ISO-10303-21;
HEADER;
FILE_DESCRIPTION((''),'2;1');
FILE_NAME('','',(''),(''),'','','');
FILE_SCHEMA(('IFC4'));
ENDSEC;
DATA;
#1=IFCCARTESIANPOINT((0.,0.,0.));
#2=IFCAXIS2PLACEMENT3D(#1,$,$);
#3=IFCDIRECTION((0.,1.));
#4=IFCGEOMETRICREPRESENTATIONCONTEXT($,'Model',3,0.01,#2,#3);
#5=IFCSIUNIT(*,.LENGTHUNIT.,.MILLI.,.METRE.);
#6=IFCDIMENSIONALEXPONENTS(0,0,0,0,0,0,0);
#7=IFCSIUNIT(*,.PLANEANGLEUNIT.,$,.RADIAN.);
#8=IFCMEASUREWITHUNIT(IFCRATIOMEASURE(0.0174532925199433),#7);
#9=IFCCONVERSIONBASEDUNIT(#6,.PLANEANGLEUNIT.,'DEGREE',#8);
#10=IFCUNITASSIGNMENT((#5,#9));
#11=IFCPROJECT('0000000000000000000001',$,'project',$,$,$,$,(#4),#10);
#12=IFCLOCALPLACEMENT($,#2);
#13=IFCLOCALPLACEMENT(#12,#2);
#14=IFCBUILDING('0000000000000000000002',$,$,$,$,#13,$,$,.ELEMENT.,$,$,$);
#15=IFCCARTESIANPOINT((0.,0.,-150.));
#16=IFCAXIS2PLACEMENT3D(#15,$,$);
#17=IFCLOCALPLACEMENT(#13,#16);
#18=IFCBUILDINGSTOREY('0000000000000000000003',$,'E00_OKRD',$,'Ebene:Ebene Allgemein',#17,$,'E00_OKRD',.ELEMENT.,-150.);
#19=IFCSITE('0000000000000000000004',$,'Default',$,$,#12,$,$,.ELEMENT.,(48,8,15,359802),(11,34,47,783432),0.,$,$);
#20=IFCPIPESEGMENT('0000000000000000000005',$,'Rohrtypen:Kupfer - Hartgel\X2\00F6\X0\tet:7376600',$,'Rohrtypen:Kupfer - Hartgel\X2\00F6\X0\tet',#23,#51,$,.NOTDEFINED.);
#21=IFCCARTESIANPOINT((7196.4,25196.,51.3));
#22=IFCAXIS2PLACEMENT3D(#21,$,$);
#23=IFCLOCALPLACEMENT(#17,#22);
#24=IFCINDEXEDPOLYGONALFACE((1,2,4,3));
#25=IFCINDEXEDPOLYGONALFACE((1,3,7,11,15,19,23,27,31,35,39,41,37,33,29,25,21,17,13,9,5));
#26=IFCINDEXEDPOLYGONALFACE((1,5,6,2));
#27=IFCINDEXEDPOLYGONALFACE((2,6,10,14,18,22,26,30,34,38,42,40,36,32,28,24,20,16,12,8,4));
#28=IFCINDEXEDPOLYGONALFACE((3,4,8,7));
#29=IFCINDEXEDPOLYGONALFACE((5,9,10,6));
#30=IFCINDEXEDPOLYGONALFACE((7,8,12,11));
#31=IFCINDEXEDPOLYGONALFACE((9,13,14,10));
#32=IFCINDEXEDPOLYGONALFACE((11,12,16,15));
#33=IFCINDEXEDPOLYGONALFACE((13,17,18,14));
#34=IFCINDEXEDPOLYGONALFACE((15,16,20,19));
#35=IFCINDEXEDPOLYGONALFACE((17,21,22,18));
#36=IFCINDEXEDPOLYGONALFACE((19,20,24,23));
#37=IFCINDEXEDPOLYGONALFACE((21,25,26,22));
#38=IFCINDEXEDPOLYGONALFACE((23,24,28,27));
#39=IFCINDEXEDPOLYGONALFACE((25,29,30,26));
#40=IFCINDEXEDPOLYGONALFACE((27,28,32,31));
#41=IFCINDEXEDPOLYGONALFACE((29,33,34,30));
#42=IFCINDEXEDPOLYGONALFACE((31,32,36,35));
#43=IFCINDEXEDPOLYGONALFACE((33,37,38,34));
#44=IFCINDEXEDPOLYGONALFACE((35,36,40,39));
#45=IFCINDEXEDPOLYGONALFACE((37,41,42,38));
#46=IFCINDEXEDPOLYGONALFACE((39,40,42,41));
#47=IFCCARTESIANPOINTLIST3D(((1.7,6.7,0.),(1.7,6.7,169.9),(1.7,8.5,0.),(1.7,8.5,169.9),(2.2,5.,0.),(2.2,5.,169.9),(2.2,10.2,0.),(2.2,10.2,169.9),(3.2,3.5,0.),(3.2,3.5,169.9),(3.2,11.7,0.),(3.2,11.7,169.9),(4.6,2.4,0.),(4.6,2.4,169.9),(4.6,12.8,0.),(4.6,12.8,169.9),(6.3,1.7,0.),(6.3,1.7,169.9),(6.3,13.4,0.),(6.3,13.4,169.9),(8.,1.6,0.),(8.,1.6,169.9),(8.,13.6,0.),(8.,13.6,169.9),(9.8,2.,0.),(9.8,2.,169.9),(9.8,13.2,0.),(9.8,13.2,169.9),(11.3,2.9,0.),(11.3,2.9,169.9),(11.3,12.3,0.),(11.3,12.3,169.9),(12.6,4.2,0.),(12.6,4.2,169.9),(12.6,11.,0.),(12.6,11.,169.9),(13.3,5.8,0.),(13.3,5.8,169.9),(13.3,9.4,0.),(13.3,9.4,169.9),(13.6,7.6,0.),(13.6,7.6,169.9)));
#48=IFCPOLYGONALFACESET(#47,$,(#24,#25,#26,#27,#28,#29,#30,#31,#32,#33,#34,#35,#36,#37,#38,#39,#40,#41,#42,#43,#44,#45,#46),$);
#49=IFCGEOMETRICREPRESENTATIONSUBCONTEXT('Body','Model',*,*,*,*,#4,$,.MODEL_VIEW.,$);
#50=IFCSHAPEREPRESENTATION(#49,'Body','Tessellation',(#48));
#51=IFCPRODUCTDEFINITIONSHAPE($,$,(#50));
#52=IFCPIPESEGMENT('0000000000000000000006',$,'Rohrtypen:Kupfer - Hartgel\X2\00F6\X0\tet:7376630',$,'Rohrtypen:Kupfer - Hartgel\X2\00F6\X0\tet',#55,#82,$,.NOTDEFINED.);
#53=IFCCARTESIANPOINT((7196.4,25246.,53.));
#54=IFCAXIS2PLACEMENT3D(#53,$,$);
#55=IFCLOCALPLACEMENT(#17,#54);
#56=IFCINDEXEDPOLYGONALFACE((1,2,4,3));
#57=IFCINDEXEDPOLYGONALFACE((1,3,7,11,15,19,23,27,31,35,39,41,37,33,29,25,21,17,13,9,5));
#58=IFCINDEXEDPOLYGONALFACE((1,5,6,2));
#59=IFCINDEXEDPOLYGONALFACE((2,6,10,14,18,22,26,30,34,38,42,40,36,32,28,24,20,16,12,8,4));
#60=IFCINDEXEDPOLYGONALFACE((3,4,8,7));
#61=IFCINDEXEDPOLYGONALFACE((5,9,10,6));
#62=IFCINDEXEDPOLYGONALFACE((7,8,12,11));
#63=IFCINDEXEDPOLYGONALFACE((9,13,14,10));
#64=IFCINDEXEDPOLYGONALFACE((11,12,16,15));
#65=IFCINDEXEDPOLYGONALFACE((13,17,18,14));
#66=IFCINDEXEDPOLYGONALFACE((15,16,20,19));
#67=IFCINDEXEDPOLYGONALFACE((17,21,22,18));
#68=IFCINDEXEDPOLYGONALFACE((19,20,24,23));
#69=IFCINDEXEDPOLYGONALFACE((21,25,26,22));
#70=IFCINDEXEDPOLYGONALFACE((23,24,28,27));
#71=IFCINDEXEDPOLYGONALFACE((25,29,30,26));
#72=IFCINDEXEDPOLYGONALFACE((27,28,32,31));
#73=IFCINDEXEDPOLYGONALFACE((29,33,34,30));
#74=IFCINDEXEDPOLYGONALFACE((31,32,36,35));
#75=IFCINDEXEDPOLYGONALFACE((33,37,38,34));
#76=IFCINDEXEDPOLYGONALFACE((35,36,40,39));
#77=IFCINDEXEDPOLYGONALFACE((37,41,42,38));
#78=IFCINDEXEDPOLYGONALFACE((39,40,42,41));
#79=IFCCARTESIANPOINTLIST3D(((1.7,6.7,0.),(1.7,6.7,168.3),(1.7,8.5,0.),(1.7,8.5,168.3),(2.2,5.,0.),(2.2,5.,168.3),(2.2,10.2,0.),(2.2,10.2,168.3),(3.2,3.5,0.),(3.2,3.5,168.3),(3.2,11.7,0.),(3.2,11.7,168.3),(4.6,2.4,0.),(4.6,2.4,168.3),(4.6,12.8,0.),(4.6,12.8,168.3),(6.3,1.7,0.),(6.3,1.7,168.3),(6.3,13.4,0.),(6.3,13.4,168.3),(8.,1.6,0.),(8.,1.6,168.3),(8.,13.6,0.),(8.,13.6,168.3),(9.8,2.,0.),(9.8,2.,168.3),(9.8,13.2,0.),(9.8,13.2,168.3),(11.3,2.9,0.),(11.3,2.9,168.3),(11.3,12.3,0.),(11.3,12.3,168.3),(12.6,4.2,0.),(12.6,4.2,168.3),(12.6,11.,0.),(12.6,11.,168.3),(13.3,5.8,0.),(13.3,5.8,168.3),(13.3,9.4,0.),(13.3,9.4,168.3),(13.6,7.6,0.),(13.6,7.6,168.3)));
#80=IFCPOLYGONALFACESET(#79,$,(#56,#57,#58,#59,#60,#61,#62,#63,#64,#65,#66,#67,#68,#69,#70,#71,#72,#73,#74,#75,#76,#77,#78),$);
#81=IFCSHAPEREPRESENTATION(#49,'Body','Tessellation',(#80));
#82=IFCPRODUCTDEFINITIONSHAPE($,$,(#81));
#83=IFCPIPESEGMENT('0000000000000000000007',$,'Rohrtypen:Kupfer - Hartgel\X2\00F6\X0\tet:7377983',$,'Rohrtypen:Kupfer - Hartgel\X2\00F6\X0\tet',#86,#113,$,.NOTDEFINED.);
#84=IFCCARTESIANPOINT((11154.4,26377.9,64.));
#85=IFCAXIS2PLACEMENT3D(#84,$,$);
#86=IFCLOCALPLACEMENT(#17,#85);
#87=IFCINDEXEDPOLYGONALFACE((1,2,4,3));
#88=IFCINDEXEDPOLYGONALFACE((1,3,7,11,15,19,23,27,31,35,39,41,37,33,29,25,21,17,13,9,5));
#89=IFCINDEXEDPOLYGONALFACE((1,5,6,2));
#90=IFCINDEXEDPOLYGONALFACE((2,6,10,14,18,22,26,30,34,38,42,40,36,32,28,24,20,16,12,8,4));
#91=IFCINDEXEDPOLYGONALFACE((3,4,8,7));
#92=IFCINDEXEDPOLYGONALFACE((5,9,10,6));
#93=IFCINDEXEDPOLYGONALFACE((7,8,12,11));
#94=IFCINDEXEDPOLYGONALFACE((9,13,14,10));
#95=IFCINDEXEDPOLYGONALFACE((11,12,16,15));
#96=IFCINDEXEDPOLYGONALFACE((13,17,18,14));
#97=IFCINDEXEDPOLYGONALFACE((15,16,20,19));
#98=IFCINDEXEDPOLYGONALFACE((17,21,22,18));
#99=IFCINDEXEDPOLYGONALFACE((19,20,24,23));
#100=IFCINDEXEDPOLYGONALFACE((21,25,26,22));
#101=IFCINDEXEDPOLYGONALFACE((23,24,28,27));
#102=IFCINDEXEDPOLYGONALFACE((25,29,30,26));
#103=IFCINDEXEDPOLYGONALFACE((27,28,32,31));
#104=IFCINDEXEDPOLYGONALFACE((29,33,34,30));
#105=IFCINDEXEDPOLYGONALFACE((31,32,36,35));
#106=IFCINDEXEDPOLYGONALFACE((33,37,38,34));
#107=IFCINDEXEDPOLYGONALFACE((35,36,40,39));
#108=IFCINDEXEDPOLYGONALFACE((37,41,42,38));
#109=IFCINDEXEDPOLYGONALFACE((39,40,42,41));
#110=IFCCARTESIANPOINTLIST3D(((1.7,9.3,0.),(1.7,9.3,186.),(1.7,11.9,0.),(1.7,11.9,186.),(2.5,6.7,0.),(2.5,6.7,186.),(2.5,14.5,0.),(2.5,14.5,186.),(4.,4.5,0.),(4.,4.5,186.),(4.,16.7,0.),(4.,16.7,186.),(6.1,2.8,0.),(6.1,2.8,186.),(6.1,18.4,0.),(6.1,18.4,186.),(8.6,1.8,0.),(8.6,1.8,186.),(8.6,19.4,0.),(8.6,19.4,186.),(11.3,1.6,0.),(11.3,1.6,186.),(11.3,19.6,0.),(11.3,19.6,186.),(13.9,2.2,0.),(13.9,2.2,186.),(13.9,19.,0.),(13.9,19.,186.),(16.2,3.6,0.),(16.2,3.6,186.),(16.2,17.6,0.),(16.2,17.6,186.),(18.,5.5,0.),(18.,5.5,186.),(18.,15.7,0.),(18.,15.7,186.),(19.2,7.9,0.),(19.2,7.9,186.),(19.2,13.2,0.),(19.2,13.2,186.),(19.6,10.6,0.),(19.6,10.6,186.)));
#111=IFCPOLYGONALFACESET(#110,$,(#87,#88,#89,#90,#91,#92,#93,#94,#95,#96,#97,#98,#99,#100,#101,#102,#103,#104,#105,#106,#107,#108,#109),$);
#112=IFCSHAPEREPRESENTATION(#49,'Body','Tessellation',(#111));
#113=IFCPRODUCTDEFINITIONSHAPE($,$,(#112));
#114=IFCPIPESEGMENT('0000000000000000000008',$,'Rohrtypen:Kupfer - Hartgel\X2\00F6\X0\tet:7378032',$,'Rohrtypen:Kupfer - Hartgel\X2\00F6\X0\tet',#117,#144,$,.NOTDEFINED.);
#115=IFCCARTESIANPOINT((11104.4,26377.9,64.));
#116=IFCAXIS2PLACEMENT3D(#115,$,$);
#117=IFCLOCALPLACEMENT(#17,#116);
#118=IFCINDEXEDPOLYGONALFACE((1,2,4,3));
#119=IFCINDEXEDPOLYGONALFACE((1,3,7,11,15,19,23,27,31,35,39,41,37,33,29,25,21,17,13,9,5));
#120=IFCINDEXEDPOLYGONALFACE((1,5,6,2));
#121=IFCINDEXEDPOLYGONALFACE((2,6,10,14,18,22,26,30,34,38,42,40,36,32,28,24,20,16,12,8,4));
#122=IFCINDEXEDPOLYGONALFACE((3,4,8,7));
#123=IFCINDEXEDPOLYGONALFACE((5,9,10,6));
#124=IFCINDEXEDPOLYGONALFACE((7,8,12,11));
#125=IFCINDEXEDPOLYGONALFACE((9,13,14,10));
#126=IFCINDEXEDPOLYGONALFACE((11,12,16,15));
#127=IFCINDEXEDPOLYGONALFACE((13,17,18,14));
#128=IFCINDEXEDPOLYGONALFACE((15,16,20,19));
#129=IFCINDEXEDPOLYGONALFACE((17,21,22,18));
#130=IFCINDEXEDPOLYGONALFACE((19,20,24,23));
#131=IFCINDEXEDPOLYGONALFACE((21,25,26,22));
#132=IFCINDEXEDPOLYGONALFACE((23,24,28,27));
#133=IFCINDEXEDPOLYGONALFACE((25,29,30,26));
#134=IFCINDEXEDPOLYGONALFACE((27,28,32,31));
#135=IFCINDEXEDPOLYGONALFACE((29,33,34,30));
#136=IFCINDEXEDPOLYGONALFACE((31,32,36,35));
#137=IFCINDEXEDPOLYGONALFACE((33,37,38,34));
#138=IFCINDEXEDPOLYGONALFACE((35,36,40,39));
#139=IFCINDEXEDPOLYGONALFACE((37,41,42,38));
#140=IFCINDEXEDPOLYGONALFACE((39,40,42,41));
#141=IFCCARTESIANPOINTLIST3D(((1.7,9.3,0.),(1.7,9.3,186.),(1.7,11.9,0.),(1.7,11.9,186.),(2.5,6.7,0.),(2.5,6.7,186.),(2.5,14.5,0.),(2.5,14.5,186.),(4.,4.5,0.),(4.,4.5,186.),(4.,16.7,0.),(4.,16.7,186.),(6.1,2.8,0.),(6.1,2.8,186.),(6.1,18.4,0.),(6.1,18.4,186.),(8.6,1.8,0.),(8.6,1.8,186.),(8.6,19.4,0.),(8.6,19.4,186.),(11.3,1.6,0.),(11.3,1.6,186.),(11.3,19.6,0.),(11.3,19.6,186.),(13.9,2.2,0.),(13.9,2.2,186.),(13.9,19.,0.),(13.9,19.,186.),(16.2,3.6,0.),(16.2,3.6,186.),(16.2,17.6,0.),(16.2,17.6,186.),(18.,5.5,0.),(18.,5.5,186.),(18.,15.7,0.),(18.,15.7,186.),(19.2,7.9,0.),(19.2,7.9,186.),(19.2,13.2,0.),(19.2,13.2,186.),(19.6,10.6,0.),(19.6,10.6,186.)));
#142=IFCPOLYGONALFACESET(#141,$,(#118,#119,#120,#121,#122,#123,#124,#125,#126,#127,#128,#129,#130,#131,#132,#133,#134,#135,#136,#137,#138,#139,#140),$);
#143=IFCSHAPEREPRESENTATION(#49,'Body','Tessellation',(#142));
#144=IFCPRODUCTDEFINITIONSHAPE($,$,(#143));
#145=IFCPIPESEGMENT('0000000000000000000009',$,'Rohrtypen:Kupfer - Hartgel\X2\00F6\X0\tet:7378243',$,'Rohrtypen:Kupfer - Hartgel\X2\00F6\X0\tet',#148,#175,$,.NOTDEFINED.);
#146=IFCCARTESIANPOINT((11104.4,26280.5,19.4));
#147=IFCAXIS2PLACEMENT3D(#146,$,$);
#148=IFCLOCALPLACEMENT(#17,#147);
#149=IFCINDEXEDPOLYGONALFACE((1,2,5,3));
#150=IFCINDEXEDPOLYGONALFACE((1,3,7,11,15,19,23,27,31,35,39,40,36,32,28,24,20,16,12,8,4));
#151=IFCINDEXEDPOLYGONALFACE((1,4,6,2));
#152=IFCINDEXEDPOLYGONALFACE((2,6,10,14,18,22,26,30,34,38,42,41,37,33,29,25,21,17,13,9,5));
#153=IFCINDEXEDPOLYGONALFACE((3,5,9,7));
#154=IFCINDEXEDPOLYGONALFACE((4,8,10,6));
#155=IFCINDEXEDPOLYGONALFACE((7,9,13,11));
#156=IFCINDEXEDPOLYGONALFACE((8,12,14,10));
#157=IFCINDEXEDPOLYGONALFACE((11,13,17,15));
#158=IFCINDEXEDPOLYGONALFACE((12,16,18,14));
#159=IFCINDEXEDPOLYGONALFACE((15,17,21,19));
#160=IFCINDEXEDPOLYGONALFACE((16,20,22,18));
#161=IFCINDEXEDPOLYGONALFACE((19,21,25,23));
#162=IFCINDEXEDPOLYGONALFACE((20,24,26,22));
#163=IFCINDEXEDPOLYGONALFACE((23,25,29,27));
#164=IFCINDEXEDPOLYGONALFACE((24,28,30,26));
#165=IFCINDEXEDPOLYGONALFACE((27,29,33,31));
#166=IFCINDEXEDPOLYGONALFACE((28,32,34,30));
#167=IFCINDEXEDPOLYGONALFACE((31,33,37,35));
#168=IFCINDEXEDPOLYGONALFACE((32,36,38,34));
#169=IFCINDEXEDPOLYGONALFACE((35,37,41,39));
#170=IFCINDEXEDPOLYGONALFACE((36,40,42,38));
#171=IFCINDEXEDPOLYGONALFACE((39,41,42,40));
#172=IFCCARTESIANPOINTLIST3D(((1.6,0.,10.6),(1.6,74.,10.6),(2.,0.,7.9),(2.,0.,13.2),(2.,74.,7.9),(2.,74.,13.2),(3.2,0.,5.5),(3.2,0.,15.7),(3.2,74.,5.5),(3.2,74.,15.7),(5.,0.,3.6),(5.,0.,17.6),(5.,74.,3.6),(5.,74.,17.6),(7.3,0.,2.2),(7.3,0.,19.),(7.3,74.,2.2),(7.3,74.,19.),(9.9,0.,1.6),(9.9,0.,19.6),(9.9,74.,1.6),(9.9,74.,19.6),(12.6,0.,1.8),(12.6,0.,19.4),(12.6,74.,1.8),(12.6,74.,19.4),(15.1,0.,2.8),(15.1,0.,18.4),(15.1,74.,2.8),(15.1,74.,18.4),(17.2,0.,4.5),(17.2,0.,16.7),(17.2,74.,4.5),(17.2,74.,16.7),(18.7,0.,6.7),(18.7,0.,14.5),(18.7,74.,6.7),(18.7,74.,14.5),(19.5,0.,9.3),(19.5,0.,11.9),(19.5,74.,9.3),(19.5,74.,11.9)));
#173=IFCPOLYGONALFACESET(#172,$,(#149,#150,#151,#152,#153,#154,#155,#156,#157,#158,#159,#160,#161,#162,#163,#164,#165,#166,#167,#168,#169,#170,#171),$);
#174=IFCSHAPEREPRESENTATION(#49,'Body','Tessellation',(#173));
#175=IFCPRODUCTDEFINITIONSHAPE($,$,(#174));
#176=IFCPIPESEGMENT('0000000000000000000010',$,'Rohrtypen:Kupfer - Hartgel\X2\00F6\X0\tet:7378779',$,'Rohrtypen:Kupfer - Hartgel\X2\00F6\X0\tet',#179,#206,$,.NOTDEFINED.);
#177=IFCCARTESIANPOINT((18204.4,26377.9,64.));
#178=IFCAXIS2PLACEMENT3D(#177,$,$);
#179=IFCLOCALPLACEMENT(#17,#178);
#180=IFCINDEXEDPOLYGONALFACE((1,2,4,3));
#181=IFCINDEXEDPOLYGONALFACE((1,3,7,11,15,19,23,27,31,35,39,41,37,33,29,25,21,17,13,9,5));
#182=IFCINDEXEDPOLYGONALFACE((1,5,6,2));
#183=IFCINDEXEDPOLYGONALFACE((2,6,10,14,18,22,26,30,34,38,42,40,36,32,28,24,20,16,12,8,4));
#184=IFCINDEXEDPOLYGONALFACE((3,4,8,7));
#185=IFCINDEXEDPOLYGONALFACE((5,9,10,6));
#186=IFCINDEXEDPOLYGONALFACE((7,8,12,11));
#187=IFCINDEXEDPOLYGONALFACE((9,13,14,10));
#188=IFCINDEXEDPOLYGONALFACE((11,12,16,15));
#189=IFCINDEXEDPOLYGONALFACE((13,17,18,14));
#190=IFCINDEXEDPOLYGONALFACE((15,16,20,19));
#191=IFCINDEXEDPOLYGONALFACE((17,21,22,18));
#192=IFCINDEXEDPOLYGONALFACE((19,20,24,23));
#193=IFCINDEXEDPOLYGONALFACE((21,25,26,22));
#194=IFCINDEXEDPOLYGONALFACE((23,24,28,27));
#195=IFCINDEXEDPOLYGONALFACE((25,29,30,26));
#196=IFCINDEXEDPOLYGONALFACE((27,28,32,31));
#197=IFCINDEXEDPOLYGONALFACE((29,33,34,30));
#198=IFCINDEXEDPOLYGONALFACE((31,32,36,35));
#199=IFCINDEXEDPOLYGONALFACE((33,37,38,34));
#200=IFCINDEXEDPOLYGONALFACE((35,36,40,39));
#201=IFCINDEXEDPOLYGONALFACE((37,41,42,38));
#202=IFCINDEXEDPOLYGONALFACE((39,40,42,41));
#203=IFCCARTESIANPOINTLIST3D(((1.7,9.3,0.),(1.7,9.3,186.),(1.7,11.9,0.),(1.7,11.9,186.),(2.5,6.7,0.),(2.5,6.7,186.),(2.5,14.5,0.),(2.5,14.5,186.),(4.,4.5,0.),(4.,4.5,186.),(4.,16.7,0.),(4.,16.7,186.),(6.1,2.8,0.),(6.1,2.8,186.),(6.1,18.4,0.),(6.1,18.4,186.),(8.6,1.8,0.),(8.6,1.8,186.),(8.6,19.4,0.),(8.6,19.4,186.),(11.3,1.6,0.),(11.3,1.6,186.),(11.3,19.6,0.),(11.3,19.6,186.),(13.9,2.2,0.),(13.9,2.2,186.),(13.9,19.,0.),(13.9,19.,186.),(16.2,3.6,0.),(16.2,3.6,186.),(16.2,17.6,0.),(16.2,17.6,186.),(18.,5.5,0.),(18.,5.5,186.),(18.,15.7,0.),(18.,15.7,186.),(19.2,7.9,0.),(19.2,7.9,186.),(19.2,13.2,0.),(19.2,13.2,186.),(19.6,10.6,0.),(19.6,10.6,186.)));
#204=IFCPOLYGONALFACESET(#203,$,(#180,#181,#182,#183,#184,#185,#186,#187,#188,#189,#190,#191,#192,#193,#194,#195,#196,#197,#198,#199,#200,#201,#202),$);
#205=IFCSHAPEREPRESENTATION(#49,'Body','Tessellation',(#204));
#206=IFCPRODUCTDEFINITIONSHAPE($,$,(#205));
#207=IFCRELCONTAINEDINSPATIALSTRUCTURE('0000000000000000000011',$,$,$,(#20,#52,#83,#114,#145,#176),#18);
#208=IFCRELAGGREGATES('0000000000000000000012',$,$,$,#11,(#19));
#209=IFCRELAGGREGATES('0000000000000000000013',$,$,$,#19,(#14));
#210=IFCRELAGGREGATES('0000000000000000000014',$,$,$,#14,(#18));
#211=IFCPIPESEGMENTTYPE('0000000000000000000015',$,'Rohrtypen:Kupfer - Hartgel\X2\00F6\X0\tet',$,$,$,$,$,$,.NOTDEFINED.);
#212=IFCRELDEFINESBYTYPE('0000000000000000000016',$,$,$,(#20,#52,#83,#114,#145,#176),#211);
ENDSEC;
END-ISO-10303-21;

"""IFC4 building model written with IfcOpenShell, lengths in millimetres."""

from ifc_helpers import new_model, entity, si_unit, converted_unit, direction, frame, frame_2d, origin, origin_2d_with_axis, place, context, subcontext, project, spatial, circle, extrude, type_object, element, save


model = new_model("IFC4")

# Units and contexts
model_context = context("Model", 3, precision=0.01, world=origin(), true_north=direction((0.0, 1.0)))
body_context = subcontext(model_context, "Body", "Model", "MODEL_VIEW")
ifc_project = project(units=[si_unit("LENGTHUNIT", "METRE", prefix="MILLI"), converted_unit("PLANEANGLEUNIT", "DEGREE", entity("IfcRatioMeasure", 0.0174532925199433), si_unit("PLANEANGLEUNIT", "RADIAN"), dimensions=[0, 0, 0, 0, 0, 0, 0])], contexts=[model_context])

# Site, building, storey
site_placement = place(None, origin())
site = spatial("IfcSite", under=ifc_project, at=site_placement, Name="Default", CompositionType="ELEMENT", RefLatitude=(48, 8, 15, 359802), RefLongitude=(11, 34, 47, 783432), RefElevation=0.0)
building_placement = place(site_placement, origin())
building = spatial("IfcBuilding", under=site, at=building_placement, CompositionType="ELEMENT")
storey_placement = place(building_placement, frame((0.0, 0.0, -150.0)))
storey = spatial("IfcBuildingStorey", under=building, at=storey_placement, Name="E00_OKRD", ObjectType="Ebene:Ebene Allgemein", LongName="E00_OKRD", CompositionType="ELEMENT", Elevation=-150.0)

# Pipe segments
pipe_segment_type = type_object("IfcPipeSegmentType", Name="Rohrtypen:Kupfer - Hartgelötet", PredefinedType="NOTDEFINED")
pipe_segment_1_placement = place(storey_placement, frame((7196.4, 25196.0, 51.3)))
element("IfcPipeSegment", 1, at=pipe_segment_1_placement, inside=storey, type_object=pipe_segment_type, Name="Rohrtypen:Kupfer - Hartgelötet:7376600", ObjectType="Rohrtypen:Kupfer - Hartgelötet", PredefinedType="NOTDEFINED", context=body_context, shape_type="SweptSolid", body=[
    extrude(circle(Radius=6.0, at=origin_2d_with_axis()), frame((7.6, 7.6, 0.0)), (0.0, 0.0, 1.0), 169.9),
])
pipe_segment_2_placement = place(storey_placement, frame((7196.4, 25246.0, 53.0)))
element("IfcPipeSegment", 2, at=pipe_segment_2_placement, inside=storey, type_object=pipe_segment_type, Name="Rohrtypen:Kupfer - Hartgelötet:7376630", ObjectType="Rohrtypen:Kupfer - Hartgelötet", PredefinedType="NOTDEFINED", context=body_context, shape_type="SweptSolid", body=[
    extrude(circle(Radius=6.0, at=origin_2d_with_axis()), frame((7.6, 7.6, 0.0)), (0.0, 0.0, 1.0), 168.3),
])
pipe_segment_3_placement = place(storey_placement, frame((11154.4, 26377.9, 64.0)))
element("IfcPipeSegment", 3, at=pipe_segment_3_placement, inside=storey, type_object=pipe_segment_type, Name="Rohrtypen:Kupfer - Hartgelötet:7377983", ObjectType="Rohrtypen:Kupfer - Hartgelötet", PredefinedType="NOTDEFINED", context=body_context, shape_type="SweptSolid", body=[
    extrude(circle(Radius=9.0, at=origin_2d_with_axis()), frame((10.6, 10.6, 0.0)), (0.0, 0.0, 1.0), 186.0),
])
pipe_segment_4_placement = place(storey_placement, frame((11104.4, 26377.9, 64.0)))
element("IfcPipeSegment", 4, at=pipe_segment_4_placement, inside=storey, type_object=pipe_segment_type, Name="Rohrtypen:Kupfer - Hartgelötet:7378032", ObjectType="Rohrtypen:Kupfer - Hartgelötet", PredefinedType="NOTDEFINED", context=body_context, shape_type="SweptSolid", body=[
    extrude(circle(Radius=9.0, at=origin_2d_with_axis()), frame((10.6, 10.6, 0.0)), (0.0, 0.0, 1.0), 186.0),
])
pipe_segment_5_placement = place(storey_placement, frame((11104.4, 26280.5, 19.4)))
element("IfcPipeSegment", 5, at=pipe_segment_5_placement, inside=storey, type_object=pipe_segment_type, Name="Rohrtypen:Kupfer - Hartgelötet:7378243", ObjectType="Rohrtypen:Kupfer - Hartgelötet", PredefinedType="NOTDEFINED", context=body_context, shape_type="SweptSolid", body=[
    extrude(circle(Radius=9.0, at=frame_2d((0.0, 0.0), x_axis=(1.0, 0.0))), frame((10.6, 0.0, 10.6), z_axis=(0.0, 1.0, 0.0), x_axis=(-1.0, 0.0, 0.0)), (0.0, 0.0, 1.0), 74.0),
])
pipe_segment_6_placement = place(storey_placement, frame((18204.4, 26377.9, 64.0)))
element("IfcPipeSegment", 6, at=pipe_segment_6_placement, inside=storey, type_object=pipe_segment_type, Name="Rohrtypen:Kupfer - Hartgelötet:7378779", ObjectType="Rohrtypen:Kupfer - Hartgelötet", PredefinedType="NOTDEFINED", context=body_context, shape_type="SweptSolid", body=[
    extrude(circle(Radius=9.0, at=origin_2d_with_axis()), frame((10.6, 10.6, 0.0)), (0.0, 0.0, 1.0), 186.0),
])

save(model, "model.ifc")
